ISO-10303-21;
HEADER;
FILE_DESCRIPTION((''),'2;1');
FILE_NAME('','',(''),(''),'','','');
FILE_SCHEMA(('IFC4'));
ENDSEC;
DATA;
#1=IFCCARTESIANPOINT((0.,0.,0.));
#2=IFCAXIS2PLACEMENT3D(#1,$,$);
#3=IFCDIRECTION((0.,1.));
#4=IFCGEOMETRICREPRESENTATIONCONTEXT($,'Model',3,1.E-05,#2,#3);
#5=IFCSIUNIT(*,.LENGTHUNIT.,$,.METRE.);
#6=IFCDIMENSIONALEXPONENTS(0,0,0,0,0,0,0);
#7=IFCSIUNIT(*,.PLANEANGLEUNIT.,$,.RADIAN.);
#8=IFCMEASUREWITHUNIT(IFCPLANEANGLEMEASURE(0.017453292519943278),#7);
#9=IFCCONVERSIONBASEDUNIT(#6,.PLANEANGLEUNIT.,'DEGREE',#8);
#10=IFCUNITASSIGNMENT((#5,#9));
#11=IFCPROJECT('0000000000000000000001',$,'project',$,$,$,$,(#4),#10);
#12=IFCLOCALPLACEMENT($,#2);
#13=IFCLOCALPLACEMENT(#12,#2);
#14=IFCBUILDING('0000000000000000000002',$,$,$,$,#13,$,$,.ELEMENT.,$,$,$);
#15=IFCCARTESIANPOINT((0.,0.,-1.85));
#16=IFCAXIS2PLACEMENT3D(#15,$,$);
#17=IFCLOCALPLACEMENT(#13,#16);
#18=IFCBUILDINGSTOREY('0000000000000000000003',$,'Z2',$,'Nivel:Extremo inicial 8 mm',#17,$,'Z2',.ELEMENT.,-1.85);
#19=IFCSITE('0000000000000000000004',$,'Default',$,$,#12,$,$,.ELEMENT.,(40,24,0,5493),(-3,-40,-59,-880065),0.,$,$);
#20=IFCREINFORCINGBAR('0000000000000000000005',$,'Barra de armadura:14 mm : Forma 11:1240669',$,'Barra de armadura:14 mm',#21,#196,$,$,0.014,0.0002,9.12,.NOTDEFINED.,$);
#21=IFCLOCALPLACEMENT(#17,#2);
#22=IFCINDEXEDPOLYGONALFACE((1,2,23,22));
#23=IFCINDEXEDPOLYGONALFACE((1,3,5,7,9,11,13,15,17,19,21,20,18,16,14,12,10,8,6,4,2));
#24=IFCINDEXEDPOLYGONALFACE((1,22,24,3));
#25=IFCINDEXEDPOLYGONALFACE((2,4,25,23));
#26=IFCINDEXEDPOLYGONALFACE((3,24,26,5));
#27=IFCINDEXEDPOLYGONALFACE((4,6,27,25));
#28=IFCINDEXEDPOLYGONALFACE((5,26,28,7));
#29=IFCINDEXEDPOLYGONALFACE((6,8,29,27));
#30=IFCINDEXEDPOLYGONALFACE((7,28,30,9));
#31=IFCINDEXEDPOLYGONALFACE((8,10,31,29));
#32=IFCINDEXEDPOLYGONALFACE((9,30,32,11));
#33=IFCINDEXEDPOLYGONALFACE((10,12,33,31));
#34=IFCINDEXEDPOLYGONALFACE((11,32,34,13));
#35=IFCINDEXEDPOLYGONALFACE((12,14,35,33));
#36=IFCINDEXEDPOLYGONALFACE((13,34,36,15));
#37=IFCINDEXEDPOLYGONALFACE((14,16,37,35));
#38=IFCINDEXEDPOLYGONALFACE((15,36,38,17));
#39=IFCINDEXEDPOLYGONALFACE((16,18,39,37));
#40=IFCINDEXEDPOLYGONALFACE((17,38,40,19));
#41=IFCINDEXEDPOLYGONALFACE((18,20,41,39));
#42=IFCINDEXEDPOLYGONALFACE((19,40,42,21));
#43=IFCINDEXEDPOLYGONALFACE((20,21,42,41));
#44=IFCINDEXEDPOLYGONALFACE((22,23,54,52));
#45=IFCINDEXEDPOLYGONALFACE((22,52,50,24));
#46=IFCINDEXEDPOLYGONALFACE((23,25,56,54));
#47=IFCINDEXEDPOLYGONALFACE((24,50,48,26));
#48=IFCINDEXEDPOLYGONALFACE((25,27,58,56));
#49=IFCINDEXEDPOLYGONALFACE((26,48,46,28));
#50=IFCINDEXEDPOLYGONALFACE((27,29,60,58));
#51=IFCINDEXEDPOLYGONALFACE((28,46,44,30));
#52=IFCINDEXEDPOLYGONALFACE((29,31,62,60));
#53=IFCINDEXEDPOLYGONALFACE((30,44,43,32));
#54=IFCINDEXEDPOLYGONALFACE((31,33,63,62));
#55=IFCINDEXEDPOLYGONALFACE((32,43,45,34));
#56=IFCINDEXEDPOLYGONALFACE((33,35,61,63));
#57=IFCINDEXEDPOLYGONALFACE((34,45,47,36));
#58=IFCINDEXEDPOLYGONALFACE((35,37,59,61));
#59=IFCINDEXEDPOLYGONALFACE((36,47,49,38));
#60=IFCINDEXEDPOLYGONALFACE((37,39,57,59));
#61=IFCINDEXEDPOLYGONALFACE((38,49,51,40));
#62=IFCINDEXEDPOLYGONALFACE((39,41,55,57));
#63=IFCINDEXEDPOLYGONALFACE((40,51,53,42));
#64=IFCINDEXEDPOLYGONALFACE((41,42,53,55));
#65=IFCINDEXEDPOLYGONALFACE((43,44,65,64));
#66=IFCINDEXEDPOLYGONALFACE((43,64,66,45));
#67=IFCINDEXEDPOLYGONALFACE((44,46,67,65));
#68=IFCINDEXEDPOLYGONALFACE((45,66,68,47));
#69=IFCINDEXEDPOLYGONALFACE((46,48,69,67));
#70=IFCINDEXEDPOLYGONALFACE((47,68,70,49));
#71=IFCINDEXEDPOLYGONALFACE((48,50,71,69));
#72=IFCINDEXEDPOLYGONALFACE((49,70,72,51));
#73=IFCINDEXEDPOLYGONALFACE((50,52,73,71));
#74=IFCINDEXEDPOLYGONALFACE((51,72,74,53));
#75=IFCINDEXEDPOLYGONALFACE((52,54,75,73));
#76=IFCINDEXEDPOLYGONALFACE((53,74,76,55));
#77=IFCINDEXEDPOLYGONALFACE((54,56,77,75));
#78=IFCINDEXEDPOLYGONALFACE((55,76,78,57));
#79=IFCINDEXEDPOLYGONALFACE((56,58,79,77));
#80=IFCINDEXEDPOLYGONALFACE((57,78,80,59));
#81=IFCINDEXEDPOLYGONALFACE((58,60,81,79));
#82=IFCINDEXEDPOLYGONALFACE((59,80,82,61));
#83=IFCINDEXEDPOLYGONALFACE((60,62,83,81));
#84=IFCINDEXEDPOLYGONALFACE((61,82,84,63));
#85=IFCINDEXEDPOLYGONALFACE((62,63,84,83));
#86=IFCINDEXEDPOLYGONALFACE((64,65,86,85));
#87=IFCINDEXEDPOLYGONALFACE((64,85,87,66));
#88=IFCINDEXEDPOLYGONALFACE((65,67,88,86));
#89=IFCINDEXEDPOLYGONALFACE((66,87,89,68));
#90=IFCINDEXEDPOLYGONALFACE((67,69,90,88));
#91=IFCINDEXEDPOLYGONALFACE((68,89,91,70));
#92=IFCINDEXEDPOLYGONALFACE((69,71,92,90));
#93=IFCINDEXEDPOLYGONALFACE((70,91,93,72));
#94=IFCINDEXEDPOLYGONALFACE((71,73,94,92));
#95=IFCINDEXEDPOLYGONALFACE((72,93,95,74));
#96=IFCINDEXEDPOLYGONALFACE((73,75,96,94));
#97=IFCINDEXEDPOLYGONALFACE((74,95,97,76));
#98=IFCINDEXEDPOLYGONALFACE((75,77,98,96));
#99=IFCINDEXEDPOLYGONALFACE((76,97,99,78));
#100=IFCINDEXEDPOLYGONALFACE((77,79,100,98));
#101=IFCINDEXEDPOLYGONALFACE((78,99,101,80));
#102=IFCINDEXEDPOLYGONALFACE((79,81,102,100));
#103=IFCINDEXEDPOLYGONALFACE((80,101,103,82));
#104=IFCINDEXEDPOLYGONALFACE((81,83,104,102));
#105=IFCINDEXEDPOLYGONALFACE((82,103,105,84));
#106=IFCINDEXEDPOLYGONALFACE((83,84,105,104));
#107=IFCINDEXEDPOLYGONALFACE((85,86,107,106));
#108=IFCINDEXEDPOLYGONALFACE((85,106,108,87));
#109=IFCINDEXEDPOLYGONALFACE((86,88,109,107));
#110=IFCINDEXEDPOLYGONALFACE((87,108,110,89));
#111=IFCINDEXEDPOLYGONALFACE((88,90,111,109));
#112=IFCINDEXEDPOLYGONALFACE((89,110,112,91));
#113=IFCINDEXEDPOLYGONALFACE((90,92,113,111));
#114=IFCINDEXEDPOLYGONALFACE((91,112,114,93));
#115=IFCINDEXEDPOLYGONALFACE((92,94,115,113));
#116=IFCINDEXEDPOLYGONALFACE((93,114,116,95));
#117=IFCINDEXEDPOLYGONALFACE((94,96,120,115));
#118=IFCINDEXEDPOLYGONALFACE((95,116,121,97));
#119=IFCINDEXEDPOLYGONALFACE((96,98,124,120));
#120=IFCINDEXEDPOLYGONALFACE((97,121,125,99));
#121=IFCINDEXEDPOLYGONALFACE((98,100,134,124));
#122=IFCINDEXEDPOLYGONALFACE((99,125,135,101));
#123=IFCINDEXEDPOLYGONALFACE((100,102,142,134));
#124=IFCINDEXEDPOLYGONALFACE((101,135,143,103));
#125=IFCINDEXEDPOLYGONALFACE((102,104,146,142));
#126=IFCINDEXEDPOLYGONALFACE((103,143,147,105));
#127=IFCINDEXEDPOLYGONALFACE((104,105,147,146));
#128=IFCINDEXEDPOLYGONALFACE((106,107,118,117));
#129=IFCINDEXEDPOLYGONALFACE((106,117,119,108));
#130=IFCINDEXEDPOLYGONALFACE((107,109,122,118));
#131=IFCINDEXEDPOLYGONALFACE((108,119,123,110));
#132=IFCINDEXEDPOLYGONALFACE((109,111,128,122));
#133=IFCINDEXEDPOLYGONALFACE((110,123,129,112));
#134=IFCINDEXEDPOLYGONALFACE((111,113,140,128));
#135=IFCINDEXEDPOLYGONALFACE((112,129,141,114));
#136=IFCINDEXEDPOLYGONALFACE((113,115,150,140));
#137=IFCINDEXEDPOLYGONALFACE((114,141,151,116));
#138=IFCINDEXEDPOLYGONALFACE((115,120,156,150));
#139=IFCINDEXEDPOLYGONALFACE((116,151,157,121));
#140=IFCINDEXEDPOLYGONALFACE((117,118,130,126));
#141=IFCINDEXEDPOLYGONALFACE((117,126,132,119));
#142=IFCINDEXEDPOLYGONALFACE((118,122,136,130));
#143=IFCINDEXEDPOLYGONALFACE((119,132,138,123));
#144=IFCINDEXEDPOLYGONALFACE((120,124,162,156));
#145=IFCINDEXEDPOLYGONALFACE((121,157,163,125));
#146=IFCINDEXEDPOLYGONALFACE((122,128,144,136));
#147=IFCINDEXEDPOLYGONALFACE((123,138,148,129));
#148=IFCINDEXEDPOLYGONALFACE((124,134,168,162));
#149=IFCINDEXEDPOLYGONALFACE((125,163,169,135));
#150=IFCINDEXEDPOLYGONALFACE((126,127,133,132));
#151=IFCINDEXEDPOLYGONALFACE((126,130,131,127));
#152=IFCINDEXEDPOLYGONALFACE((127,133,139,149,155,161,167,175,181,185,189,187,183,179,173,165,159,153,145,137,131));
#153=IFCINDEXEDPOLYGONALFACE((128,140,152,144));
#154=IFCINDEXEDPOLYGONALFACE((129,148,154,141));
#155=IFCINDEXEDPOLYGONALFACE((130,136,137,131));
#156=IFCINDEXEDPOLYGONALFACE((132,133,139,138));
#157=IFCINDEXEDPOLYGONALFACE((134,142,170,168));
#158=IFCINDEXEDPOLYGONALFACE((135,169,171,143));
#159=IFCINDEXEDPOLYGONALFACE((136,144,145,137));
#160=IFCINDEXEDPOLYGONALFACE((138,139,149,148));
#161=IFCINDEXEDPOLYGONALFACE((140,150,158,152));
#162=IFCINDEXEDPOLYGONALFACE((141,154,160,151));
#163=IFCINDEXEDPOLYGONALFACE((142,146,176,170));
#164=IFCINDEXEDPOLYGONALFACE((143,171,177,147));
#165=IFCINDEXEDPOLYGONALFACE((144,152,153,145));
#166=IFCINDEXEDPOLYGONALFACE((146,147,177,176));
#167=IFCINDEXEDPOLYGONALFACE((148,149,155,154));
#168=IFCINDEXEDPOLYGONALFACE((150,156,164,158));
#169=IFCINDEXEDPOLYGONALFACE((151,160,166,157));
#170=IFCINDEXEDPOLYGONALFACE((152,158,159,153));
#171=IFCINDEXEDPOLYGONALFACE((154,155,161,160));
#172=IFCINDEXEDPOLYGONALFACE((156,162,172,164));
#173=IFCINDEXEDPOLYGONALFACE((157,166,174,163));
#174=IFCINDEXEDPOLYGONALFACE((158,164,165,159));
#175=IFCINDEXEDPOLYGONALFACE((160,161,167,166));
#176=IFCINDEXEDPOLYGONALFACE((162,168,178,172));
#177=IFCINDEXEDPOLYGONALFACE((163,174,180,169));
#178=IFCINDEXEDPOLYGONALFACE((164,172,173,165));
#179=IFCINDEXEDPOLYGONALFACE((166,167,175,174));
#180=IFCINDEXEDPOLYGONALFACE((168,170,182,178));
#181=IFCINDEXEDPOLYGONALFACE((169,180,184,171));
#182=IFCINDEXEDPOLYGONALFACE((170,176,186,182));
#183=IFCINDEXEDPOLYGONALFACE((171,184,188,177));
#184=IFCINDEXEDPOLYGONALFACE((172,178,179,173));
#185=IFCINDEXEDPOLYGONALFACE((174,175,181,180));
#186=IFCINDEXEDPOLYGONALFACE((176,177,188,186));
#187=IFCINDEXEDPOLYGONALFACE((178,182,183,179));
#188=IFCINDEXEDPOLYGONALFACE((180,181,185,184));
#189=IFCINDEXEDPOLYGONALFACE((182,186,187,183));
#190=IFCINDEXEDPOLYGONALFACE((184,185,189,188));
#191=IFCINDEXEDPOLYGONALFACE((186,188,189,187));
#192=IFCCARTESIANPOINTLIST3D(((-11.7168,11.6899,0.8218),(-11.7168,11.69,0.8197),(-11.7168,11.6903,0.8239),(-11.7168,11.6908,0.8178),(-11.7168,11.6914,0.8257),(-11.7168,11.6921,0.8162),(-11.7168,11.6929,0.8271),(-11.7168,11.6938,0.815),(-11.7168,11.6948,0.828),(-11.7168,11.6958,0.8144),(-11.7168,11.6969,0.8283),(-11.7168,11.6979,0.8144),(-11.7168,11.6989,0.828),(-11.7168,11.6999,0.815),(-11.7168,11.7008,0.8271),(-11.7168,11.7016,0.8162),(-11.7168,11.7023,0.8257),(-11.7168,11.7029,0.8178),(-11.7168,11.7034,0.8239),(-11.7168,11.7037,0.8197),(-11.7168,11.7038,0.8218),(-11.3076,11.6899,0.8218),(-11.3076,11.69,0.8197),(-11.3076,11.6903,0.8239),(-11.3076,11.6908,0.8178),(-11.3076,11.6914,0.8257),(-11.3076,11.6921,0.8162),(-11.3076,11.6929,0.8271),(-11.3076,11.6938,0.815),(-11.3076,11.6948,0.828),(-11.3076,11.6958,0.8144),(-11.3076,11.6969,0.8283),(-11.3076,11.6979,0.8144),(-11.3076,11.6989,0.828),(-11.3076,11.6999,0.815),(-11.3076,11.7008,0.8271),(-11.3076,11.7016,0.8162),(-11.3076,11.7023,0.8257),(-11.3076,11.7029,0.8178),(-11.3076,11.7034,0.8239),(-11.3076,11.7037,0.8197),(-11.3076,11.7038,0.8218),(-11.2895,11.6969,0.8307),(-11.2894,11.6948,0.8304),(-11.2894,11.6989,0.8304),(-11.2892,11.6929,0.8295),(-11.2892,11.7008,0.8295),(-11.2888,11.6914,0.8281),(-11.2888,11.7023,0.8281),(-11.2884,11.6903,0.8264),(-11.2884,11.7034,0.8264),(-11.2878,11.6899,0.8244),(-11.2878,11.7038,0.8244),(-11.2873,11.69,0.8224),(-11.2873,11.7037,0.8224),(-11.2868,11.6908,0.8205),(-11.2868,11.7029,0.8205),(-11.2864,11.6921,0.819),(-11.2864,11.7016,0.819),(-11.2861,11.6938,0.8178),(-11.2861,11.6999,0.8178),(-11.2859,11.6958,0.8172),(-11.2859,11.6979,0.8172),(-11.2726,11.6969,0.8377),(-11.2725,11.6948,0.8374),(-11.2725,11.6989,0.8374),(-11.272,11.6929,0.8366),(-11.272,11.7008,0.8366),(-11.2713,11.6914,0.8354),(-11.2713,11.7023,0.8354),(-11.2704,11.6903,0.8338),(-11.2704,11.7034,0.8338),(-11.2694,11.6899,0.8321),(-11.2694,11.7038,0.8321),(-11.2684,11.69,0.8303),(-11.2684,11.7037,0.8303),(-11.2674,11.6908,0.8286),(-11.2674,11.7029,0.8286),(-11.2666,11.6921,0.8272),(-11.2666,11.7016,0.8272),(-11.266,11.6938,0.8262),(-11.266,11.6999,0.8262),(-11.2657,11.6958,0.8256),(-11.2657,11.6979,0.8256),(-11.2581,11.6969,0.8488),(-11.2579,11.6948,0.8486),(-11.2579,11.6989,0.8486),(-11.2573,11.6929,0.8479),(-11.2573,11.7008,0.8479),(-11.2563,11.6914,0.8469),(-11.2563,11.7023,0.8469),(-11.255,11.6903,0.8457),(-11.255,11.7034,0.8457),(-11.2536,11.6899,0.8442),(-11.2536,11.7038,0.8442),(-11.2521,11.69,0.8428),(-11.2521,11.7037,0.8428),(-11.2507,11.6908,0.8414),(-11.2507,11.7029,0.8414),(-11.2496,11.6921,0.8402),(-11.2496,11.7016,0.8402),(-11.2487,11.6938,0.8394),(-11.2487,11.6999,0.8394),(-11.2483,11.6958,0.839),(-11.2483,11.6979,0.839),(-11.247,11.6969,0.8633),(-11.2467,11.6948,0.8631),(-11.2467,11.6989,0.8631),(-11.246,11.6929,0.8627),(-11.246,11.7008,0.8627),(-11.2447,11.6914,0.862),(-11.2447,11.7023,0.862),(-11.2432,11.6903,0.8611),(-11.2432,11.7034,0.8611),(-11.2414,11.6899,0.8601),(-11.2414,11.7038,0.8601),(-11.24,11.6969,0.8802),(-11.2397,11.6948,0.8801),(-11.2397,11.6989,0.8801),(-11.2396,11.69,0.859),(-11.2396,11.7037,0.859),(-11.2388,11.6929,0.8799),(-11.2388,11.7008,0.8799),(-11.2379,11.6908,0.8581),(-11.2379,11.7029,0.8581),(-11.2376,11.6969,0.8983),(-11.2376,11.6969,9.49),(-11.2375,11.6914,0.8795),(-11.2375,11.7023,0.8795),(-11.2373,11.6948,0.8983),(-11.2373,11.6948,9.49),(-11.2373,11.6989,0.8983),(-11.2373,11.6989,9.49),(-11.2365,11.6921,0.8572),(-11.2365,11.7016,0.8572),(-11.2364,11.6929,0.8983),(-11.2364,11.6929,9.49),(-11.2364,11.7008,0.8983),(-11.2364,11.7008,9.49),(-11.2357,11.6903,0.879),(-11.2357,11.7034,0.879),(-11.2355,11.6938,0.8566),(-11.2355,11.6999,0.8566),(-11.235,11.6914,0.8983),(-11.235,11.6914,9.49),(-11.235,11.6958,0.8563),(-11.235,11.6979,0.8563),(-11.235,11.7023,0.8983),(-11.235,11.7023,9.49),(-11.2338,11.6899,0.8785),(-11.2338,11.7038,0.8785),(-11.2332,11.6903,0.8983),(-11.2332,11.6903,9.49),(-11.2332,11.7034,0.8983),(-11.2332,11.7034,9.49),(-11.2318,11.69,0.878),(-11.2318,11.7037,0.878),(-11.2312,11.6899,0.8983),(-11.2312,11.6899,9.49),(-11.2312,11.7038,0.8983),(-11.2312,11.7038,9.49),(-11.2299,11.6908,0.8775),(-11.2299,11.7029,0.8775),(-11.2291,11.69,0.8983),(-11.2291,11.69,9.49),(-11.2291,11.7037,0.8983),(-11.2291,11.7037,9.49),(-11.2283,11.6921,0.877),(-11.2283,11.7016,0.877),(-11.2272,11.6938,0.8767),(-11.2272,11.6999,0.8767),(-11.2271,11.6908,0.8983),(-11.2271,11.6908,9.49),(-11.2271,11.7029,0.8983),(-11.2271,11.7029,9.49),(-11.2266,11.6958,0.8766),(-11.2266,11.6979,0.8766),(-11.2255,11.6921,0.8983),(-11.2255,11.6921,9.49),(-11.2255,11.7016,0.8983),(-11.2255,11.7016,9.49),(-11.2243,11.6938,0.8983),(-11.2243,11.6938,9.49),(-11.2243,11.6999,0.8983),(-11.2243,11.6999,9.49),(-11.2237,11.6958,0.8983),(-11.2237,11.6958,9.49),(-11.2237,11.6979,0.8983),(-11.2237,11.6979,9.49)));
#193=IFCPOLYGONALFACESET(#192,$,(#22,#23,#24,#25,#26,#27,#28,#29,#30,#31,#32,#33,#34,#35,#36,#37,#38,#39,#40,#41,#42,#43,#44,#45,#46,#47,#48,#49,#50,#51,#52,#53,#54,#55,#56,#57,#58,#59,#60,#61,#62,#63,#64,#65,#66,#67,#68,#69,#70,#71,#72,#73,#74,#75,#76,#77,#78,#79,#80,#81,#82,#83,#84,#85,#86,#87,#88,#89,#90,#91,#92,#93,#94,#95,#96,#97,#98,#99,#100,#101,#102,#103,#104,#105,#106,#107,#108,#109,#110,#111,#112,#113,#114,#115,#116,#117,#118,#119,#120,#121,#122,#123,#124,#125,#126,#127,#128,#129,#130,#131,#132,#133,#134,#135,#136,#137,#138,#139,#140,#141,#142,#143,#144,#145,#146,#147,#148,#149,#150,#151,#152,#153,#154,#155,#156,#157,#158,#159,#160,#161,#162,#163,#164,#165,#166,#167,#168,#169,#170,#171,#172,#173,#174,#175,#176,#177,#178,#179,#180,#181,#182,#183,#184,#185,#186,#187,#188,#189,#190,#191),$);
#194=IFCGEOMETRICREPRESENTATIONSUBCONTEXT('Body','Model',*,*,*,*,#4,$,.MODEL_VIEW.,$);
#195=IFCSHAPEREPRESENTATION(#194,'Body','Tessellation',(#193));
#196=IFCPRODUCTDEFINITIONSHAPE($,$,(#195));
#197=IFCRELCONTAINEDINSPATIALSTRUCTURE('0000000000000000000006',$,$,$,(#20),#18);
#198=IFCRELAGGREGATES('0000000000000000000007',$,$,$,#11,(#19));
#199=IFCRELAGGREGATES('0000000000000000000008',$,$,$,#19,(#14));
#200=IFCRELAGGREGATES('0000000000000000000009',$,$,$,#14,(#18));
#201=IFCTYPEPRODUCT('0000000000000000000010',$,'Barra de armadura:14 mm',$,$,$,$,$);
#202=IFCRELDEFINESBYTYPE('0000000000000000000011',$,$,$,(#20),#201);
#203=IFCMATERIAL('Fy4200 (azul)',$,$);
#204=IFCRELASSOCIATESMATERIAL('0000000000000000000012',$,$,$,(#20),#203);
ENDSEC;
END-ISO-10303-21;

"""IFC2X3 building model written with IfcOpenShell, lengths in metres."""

from ifc_helpers import new_model, entity, si_unit, converted_unit, direction, frame, origin, place, context, subcontext, project, spatial, material, type_object, element, save


model = new_model("IFC2X3")

# Units and contexts
model_context = context("Model", 3, precision=1e-05, world=origin(), true_north=direction((0.0, 1.0)))
body_context = subcontext(model_context, "Body", "Model", "MODEL_VIEW")
ifc_project = project(units=[si_unit("LENGTHUNIT", "METRE"), converted_unit("PLANEANGLEUNIT", "DEGREE", entity("IfcPlaneAngleMeasure", 0.017453292519943278), si_unit("PLANEANGLEUNIT", "RADIAN"), dimensions=[0, 0, 0, 0, 0, 0, 0])], contexts=[model_context])

# Site, building, storey
site_placement = place(None, origin())
site = spatial("IfcSite", under=ifc_project, at=site_placement, Name="Default", CompositionType="ELEMENT", RefLatitude=(40, 24, 0, 5493), RefLongitude=(-3, -40, -59, -880065), RefElevation=0.0)
building_placement = place(site_placement, origin())
building = spatial("IfcBuilding", under=site, at=building_placement, CompositionType="ELEMENT")
storey_placement = place(building_placement, frame((0.0, 0.0, -1.85)))
storey = spatial("IfcBuildingStorey", under=building, at=storey_placement, Name="Z2", ObjectType="Nivel:Extremo inicial 8 mm", LongName="Z2", CompositionType="ELEMENT", Elevation=-1.85)

# Reinforcing bar
ifc_material_1 = material(Name="Fy4200 (azul)")
type_product_1 = type_object("IfcTypeProduct", Name="Barra de armadura:14 mm")
reinforcing_bar_1_placement = place(storey_placement, origin())
element("IfcReinforcingBar", 1, at=reinforcing_bar_1_placement, inside=storey, type_object=type_product_1, material=ifc_material_1, Name="Barra de armadura:14 mm : Forma 11:1240669", ObjectType="Barra de armadura:14 mm", BarLength=9.12, BarRole="NOTDEFINED", CrossSectionArea=0.0002, NominalDiameter=0.014, context=body_context, shape_type="AdvancedSweptSolid", body=[
    entity("IfcSweptDiskSolid", entity("IfcCompositeCurve", [entity("IfcCompositeCurveSegment", "CONTINUOUS", True, entity("IfcPolyline", [entity("IfcCartesianPoint", [-11.2306, 11.6969, 9.49]), entity("IfcCartesianPoint", [-11.2306, 11.6969, 0.8983])])), entity("IfcCompositeCurveSegment", "CONTINUOUS", True, entity("IfcTrimmedCurve", entity("IfcCircle", entity("IfcAxis2Placement3D", entity("IfcCartesianPoint", [-11.3076, 11.6969, 0.8983]), entity("IfcDirection", [0.0, 1.0, 0.0]), entity("IfcDirection", [0.0, 0.0, -1.0])), 0.077), [entity("IfcParameterValue", 270.0)], [entity("IfcParameterValue", 360.0)], True, "PARAMETER")), entity("IfcCompositeCurveSegment", "CONTINUOUS", True, entity("IfcPolyline", [entity("IfcCartesianPoint", [-11.3076, 11.6969, 0.8213]), entity("IfcCartesianPoint", [-11.7168, 11.6969, 0.8213])]))], False), 0.007, None, 0.0, 92.0),
])

save(model, "model.ifc")
